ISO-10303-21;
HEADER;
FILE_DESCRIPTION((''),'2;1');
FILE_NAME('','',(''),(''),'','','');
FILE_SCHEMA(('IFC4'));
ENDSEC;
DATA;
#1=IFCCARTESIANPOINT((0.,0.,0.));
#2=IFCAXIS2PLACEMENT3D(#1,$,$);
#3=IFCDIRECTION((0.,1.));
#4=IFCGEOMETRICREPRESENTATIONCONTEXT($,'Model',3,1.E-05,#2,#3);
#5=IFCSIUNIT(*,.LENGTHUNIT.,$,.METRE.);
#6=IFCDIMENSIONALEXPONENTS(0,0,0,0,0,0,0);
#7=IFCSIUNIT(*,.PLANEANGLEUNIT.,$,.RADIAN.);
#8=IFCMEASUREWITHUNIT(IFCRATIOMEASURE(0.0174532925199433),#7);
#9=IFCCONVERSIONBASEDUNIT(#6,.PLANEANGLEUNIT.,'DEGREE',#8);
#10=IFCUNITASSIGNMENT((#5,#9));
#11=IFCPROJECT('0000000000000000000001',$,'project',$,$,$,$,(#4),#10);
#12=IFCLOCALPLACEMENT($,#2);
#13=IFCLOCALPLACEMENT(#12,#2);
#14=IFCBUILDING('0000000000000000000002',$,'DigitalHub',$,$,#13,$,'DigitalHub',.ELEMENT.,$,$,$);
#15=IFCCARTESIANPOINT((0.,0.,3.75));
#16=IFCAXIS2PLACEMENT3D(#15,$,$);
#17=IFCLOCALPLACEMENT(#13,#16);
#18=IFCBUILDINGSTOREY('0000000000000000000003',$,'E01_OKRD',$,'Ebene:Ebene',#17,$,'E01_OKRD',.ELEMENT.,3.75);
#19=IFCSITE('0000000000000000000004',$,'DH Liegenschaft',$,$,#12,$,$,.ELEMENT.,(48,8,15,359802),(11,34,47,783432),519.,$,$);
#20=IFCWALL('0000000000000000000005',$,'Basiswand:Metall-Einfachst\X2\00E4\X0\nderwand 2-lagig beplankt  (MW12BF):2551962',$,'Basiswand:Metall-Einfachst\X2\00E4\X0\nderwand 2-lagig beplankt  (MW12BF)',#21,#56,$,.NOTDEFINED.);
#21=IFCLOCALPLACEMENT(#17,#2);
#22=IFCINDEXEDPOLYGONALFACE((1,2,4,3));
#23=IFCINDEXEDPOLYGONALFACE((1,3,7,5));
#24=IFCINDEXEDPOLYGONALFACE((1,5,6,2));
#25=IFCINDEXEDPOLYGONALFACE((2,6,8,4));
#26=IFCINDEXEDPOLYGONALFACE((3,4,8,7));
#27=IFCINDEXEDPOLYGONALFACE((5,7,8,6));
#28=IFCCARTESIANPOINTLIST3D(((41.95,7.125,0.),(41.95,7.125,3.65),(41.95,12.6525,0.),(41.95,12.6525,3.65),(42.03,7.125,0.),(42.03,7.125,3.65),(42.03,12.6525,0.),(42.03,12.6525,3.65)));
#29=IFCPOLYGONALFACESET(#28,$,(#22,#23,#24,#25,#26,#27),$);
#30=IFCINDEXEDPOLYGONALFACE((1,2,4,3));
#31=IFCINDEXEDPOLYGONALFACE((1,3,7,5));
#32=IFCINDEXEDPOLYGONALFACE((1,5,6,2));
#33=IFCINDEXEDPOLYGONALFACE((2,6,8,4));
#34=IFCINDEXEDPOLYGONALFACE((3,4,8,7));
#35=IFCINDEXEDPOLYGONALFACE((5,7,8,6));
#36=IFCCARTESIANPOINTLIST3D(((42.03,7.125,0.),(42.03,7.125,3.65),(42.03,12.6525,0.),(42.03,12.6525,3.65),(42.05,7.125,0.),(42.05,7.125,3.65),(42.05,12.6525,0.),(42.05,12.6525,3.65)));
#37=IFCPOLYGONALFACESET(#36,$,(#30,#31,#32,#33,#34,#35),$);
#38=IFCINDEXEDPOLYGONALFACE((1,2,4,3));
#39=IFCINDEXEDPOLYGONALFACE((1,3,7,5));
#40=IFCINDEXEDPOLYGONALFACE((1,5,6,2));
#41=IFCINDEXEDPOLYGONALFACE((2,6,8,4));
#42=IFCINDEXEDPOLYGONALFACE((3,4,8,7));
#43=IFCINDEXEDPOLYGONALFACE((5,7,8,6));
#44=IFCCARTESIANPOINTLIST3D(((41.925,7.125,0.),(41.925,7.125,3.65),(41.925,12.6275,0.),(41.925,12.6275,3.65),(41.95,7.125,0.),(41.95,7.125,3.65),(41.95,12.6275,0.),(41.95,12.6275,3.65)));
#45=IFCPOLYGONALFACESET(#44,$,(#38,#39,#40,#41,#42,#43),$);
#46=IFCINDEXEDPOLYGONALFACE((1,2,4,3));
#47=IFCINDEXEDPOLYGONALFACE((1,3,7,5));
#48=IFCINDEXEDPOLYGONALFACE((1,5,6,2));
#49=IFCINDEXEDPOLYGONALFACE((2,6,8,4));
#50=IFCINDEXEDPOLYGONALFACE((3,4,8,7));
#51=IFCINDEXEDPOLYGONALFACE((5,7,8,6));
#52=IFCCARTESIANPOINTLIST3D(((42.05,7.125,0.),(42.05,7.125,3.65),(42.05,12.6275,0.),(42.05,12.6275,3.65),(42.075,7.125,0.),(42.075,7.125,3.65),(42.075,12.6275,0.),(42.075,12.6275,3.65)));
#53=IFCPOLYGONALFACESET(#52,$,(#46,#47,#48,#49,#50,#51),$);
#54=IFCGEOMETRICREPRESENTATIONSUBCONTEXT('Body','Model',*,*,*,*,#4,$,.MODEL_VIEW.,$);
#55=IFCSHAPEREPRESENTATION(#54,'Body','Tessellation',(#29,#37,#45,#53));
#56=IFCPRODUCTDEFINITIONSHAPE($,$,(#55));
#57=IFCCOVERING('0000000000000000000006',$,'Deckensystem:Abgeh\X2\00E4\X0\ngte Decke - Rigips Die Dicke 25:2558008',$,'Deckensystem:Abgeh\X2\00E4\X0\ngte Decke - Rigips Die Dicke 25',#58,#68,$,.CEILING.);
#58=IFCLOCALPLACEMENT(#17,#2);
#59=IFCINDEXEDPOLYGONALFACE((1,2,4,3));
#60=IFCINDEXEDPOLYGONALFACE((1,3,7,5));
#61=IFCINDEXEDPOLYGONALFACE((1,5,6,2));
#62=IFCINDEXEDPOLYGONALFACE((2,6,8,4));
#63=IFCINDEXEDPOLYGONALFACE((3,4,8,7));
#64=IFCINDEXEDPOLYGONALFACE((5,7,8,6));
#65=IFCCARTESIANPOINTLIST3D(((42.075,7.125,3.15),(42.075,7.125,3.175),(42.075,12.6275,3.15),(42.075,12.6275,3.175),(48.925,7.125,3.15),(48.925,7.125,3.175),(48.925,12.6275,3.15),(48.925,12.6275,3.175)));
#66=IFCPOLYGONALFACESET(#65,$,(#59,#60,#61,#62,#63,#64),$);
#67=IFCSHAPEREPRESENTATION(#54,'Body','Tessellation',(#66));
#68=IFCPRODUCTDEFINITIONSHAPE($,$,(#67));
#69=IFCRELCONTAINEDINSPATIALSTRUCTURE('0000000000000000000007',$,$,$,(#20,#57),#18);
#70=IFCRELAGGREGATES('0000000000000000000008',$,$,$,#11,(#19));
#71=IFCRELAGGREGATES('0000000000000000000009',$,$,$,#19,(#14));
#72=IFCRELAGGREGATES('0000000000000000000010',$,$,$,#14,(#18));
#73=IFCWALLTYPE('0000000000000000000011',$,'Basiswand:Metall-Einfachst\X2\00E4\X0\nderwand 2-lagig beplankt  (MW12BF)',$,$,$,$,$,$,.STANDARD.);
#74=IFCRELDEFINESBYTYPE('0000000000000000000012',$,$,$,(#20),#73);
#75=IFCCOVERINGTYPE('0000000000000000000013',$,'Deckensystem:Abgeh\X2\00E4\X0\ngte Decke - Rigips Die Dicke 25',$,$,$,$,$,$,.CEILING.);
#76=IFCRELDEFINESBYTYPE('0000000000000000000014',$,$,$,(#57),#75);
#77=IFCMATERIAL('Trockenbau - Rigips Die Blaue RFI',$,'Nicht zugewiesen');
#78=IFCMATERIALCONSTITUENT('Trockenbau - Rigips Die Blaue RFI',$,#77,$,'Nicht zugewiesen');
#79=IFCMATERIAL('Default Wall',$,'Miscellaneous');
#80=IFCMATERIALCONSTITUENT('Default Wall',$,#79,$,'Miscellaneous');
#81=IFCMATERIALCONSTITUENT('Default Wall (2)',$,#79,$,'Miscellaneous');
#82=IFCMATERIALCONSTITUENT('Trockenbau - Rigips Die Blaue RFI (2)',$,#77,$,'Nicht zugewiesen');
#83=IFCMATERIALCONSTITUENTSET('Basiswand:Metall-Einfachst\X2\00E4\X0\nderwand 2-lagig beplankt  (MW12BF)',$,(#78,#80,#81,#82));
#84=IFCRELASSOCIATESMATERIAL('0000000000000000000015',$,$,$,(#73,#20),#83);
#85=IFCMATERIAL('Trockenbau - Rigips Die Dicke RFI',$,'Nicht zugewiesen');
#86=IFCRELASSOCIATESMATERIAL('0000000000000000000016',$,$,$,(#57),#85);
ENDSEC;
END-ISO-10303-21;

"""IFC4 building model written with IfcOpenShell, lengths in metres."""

from ifc_helpers import new_model, entity, si_unit, converted_unit, direction, frame, origin, place, context, subcontext, project, spatial, indexed_curve, outline, extrude, material, constituent, constituent_set, type_object, element, save


model = new_model("IFC4")

# Units and contexts
model_context = context("Model", 3, precision=1e-05, world=origin(), true_north=direction((0.0, 1.0)))
body_context = subcontext(model_context, "Body", "Model", "MODEL_VIEW")
ifc_project = project(units=[si_unit("LENGTHUNIT", "METRE"), converted_unit("PLANEANGLEUNIT", "DEGREE", entity("IfcRatioMeasure", 0.0174532925199433), si_unit("PLANEANGLEUNIT", "RADIAN"), dimensions=[0, 0, 0, 0, 0, 0, 0])], contexts=[model_context])

# Site, building, storey
site_placement = place(None, frame((0.0, 0.0, 0.0)))
site = spatial("IfcSite", under=ifc_project, at=site_placement, Name="DH Liegenschaft", CompositionType="ELEMENT", RefLatitude=(48, 8, 15, 359802), RefLongitude=(11, 34, 47, 783432), RefElevation=519.0)
building_placement = place(site_placement, origin())
building = spatial("IfcBuilding", under=site, at=building_placement, Name="DigitalHub", LongName="DigitalHub", CompositionType="ELEMENT")
storey_placement = place(building_placement, frame((0.0, 0.0, 3.75)))
storey = spatial("IfcBuildingStorey", under=building, at=storey_placement, Name="E01_OKRD", ObjectType="Ebene:Ebene", LongName="E01_OKRD", CompositionType="ELEMENT", Elevation=3.75)

# Wall
ifc_material_1 = material(Name="Trockenbau - Rigips Die Blaue RFI", Category="Nicht zugewiesen")
ifc_constituent_1 = constituent(ifc_material_1, Name="Trockenbau - Rigips Die Blaue RFI", Category="Nicht zugewiesen")
ifc_material_2 = material(Name="Default Wall", Category="Miscellaneous")
ifc_constituent_2 = constituent(ifc_material_2, Name="Default Wall", Category="Miscellaneous")
ifc_constituent_3 = constituent(ifc_material_2, Name="Default Wall (2)", Category="Miscellaneous")
ifc_constituent_4 = constituent(ifc_material_1, Name="Trockenbau - Rigips Die Blaue RFI (2)", Category="Nicht zugewiesen")
ifc_constituent_set_1 = constituent_set(constituents=[ifc_constituent_1, ifc_constituent_2, ifc_constituent_3, ifc_constituent_4], Name="Basiswand:Metall-Einfachständerwand 2-lagig beplankt  (MW12BF)")
wall_type_1 = type_object("IfcWallType", Name="Basiswand:Metall-Einfachständerwand 2-lagig beplankt  (MW12BF)", PredefinedType="STANDARD", material=ifc_constituent_set_1)
wall_1_placement = place(storey_placement, frame((42.0, 7.125, 0.0), z_axis=(0.0, 0.0, 1.0), x_axis=(0.0, 1.0, 0.0)))
element("IfcWall", 1, at=wall_1_placement, inside=storey, type_object=wall_type_1, material=ifc_constituent_set_1, Name="Basiswand:Metall-Einfachständerwand 2-lagig beplankt  (MW12BF):2551962", ObjectType="Basiswand:Metall-Einfachständerwand 2-lagig beplankt  (MW12BF)", PredefinedType="NOTDEFINED", context=body_context, shape_type="SweptSolid", body=[
    extrude(outline(indexed_curve([(-2.7638, -0.04), (2.7638, -0.04), (2.7638, 0.04), (-2.7638, 0.04), (-2.7638, -0.04)], self_intersect=False)), frame((2.7638, 0.01, 0.0)), (0.0, 0.0, 1.0), 3.65),
    extrude(outline(indexed_curve([(-2.7638, -0.01), (2.7638, -0.01), (2.7638, 0.01), (-2.7638, 0.01), (-2.7638, -0.01)], self_intersect=False)), frame((2.7638, -0.04, 0.0)), (0.0, 0.0, 1.0), 3.65),
    extrude(outline(indexed_curve([(-0.0125, -2.7513), (0.0125, -2.7513), (0.0125, 2.7513), (-0.0125, 2.7513), (-0.0125, -2.7513)], self_intersect=False)), frame((2.7513, 0.0625, 0.0), z_axis=(0.0, 0.0, 1.0), x_axis=(0.0, -1.0, 0.0)), (0.0, 0.0, 1.0), 3.65),
    extrude(outline(indexed_curve([(-0.0125, -2.7513), (0.0125, -2.7513), (0.0125, 2.7513), (-0.0125, 2.7513), (-0.0125, -2.7513)], self_intersect=False)), frame((2.7513, -0.0625, 0.0), z_axis=(0.0, 0.0, 1.0), x_axis=(0.0, 1.0, 0.0)), (0.0, 0.0, 1.0), 3.65),
])

# Covering
ifc_material_3 = material(Name="Trockenbau - Rigips Die Dicke RFI", Category="Nicht zugewiesen")
covering_type = type_object("IfcCoveringType", Name="Deckensystem:Abgehängte Decke - Rigips Die Dicke 25", PredefinedType="CEILING")
covering_placement = place(storey_placement, frame((42.075, 7.125, 3.15)))
element("IfcCovering", 2, at=covering_placement, inside=storey, type_object=covering_type, material=ifc_material_3, Name="Deckensystem:Abgehängte Decke - Rigips Die Dicke 25:2558008", ObjectType="Deckensystem:Abgehängte Decke - Rigips Die Dicke 25", PredefinedType="CEILING", context=body_context, shape_type="SweptSolid", body=[
    extrude(outline(indexed_curve([(-2.7512, -3.425), (2.7512, -3.425), (2.7512, 3.425), (-2.7512, 3.425), (-2.7512, -3.425)], self_intersect=False)), frame((3.425, 2.7512, 0.0), z_axis=(0.0, 0.0, 1.0), x_axis=(0.0, -1.0, 0.0)), (0.0, 0.0, 1.0), 0.025),
])

save(model, "model.ifc")
